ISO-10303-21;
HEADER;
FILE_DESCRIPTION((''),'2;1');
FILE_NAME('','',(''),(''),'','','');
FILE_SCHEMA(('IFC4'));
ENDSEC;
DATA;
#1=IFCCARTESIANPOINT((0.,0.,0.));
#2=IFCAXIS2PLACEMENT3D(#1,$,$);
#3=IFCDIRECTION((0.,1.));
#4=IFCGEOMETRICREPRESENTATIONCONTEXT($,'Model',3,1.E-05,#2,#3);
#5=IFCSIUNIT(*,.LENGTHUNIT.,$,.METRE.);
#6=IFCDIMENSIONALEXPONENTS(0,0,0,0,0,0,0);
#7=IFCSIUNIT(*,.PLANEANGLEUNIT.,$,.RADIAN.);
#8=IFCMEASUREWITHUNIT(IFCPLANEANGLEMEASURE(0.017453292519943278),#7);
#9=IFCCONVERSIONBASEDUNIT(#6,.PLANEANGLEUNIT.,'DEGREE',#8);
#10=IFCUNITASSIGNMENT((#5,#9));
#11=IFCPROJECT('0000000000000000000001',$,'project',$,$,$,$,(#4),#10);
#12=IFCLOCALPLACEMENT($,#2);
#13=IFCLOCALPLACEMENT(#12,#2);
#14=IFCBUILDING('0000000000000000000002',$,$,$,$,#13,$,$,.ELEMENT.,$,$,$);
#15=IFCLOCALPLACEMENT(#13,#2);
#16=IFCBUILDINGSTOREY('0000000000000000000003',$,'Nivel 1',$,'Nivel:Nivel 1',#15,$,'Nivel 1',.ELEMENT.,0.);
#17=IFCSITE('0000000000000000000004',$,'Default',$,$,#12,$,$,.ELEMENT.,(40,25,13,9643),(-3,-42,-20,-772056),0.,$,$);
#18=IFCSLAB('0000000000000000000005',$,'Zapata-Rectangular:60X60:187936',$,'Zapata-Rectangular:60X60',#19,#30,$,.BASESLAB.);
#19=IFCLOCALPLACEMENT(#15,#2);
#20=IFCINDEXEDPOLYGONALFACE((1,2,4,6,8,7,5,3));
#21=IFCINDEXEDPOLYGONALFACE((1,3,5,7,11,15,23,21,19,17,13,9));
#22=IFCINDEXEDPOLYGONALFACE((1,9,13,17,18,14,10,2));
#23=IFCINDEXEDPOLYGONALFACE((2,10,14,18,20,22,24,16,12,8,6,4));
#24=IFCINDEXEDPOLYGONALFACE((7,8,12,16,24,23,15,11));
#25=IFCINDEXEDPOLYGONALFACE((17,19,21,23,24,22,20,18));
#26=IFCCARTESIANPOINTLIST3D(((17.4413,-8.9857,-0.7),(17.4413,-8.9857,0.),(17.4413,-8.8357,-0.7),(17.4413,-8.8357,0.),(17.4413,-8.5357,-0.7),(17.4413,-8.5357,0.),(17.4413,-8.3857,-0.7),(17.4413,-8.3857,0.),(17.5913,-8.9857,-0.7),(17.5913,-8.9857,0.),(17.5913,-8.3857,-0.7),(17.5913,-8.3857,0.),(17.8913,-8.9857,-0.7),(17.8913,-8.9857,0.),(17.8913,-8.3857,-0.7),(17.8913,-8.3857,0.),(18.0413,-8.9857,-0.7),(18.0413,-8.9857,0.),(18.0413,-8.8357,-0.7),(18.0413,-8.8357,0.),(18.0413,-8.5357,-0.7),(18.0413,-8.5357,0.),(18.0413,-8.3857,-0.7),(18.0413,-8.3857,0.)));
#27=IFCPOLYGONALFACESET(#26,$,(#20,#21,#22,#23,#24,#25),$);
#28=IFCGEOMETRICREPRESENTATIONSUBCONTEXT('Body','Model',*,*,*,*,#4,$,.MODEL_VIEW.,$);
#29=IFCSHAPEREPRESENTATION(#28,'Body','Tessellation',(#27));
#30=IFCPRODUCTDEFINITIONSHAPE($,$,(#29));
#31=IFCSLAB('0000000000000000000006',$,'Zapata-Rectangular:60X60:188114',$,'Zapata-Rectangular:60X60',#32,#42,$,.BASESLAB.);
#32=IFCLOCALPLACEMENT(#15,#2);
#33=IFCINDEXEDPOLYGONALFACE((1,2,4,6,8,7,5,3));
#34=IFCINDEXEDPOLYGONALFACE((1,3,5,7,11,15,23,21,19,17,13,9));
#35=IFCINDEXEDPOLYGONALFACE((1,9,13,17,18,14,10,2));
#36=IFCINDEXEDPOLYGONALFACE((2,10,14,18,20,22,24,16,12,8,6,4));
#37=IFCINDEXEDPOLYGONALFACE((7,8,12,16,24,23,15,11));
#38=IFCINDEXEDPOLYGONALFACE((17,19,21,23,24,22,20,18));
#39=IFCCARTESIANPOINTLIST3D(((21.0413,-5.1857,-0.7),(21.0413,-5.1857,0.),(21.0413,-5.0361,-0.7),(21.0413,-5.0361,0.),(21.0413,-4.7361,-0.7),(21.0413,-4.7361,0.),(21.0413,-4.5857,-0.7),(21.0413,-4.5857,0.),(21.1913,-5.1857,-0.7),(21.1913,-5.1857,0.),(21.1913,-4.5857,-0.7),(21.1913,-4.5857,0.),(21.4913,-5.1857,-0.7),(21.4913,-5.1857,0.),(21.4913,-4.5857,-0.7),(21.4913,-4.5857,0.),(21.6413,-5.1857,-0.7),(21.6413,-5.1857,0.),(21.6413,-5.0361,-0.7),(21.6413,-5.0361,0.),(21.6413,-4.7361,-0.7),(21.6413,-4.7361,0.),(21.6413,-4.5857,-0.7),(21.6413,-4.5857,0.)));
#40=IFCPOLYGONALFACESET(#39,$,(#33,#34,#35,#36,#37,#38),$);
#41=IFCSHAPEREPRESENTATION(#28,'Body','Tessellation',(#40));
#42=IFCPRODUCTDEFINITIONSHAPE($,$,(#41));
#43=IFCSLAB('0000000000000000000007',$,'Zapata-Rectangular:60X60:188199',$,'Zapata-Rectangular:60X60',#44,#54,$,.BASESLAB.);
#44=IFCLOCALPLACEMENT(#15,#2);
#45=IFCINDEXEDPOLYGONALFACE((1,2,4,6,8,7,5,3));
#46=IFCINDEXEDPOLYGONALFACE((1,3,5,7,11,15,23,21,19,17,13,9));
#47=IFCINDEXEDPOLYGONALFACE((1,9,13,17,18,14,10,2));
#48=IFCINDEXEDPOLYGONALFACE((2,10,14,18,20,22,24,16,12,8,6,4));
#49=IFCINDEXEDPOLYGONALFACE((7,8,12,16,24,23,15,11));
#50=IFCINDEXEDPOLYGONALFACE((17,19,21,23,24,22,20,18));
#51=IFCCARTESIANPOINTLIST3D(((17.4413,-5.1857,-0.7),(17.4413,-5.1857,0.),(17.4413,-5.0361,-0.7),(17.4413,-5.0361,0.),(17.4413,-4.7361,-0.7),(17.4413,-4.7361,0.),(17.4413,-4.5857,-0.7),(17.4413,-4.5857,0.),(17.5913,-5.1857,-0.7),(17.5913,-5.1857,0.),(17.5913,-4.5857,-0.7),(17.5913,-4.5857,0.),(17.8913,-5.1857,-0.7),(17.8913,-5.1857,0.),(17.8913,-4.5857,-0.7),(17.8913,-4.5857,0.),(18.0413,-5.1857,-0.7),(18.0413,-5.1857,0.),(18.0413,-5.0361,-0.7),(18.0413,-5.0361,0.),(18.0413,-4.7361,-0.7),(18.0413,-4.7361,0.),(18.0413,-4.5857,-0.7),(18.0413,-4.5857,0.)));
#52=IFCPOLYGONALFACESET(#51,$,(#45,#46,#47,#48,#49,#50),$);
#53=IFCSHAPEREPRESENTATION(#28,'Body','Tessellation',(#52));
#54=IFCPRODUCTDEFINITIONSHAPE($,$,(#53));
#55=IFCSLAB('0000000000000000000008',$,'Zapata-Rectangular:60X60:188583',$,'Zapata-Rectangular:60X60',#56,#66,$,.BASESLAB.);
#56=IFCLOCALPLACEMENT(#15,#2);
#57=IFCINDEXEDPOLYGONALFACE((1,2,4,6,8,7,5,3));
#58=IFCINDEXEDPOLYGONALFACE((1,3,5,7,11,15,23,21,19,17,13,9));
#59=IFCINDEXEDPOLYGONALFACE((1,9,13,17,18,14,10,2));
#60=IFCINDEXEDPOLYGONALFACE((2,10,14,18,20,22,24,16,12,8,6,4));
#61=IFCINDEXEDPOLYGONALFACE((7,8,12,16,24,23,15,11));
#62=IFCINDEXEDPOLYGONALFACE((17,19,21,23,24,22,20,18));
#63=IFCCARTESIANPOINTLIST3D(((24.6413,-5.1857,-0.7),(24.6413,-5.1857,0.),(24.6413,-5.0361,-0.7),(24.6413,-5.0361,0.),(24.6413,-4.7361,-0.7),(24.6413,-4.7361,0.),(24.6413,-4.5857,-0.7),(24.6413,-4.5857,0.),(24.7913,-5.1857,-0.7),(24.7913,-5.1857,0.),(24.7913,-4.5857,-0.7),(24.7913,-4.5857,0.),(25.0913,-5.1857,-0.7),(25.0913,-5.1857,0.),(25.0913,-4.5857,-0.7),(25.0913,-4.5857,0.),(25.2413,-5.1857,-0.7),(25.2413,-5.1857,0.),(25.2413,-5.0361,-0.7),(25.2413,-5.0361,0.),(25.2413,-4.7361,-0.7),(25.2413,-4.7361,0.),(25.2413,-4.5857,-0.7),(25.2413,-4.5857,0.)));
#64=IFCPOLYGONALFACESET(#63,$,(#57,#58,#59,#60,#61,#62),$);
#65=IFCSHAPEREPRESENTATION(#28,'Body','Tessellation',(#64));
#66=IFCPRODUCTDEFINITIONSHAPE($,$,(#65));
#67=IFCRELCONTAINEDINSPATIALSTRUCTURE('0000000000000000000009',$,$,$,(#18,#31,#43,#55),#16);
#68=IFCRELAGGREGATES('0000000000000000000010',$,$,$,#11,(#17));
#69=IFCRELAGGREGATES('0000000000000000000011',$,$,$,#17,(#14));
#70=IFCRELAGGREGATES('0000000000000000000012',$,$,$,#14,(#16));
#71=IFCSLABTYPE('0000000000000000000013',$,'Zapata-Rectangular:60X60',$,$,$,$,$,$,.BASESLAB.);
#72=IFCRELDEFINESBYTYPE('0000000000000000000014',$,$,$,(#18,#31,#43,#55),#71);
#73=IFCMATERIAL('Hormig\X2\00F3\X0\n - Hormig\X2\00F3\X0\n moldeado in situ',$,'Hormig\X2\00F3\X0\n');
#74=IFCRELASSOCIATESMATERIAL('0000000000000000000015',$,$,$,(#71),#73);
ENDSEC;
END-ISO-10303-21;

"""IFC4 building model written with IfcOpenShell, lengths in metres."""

from ifc_helpers import new_model, entity, si_unit, converted_unit, direction, frame, origin, place, context, subcontext, project, spatial, indexed_curve, outline, extrude, material, type_object, element, save


model = new_model("IFC4")

# Units and contexts
model_context = context("Model", 3, precision=1e-05, world=origin(), true_north=direction((0.0, 1.0)))
body_context = subcontext(model_context, "Body", "Model", "MODEL_VIEW")
ifc_project = project(units=[si_unit("LENGTHUNIT", "METRE"), converted_unit("PLANEANGLEUNIT", "DEGREE", entity("IfcPlaneAngleMeasure", 0.017453292519943278), si_unit("PLANEANGLEUNIT", "RADIAN"), dimensions=[0, 0, 0, 0, 0, 0, 0])], contexts=[model_context])

# Site, building, storey
site_placement = place(None, origin())
site = spatial("IfcSite", under=ifc_project, at=site_placement, Name="Default", CompositionType="ELEMENT", RefLatitude=(40, 25, 13, 9643), RefLongitude=(-3, -42, -20, -772056), RefElevation=0.0)
building_placement = place(site_placement, origin())
building = spatial("IfcBuilding", under=site, at=building_placement, CompositionType="ELEMENT")
storey_placement = place(building_placement, origin())
storey = spatial("IfcBuildingStorey", under=building, at=storey_placement, Name="Nivel 1", ObjectType="Nivel:Nivel 1", LongName="Nivel 1", CompositionType="ELEMENT", Elevation=0.0)

# Slabs
ifc_material_1 = material(Name="Hormigón - Hormigón moldeado in situ", Category="Hormigón")
slab_type = type_object("IfcSlabType", Name="Zapata-Rectangular:60X60", PredefinedType="BASESLAB", material=ifc_material_1)
slab_1_placement = place(storey_placement, origin())
element("IfcSlab", 1, at=slab_1_placement, inside=storey, type_object=slab_type, Name="Zapata-Rectangular:60X60:187936", ObjectType="Zapata-Rectangular:60X60", PredefinedType="BASESLAB", context=body_context, shape_type="SweptSolid", body=[
    extrude(outline(indexed_curve([(-0.3, -0.3), (-0.15, -0.3), (0.15, -0.3), (0.3, -0.3), (0.3, -0.15), (0.3, 0.15), (0.3, 0.3), (0.15, 0.3), (-0.15, 0.3), (-0.3, 0.3), (-0.3, 0.15), (-0.3, -0.15), (-0.3, -0.3)], self_intersect=False)), frame((17.7413, -8.6857, -0.7), z_axis=(0.0, 0.0, 1.0), x_axis=(-1.0, 0.0, 0.0)), (0.0, 0.0, 1.0), 0.7),
])
slab_2_placement = place(storey_placement, origin())
element("IfcSlab", 2, at=slab_2_placement, inside=storey, type_object=slab_type, Name="Zapata-Rectangular:60X60:188114", ObjectType="Zapata-Rectangular:60X60", PredefinedType="BASESLAB", context=body_context, shape_type="SweptSolid", body=[
    extrude(outline(indexed_curve([(-0.3, -0.3001), (-0.15, -0.3001), (0.15, -0.3001), (0.3, -0.3001), (0.3, -0.1498), (0.3, 0.1502), (0.3, 0.2999), (0.15, 0.2999), (-0.15, 0.2999), (-0.3, 0.2999), (-0.3, 0.1502), (-0.3, -0.1498), (-0.3, -0.3001)], self_intersect=False)), frame((21.3413, -4.8858, -0.7), z_axis=(0.0, 0.0, 1.0), x_axis=(-1.0, 0.0, 0.0)), (0.0, 0.0, 1.0), 0.7),
])
slab_3_placement = place(storey_placement, origin())
element("IfcSlab", 3, at=slab_3_placement, inside=storey, type_object=slab_type, Name="Zapata-Rectangular:60X60:188199", ObjectType="Zapata-Rectangular:60X60", PredefinedType="BASESLAB", context=body_context, shape_type="SweptSolid", body=[
    extrude(outline(indexed_curve([(-0.3, -0.3001), (-0.15, -0.3001), (0.15, -0.3001), (0.3, -0.3001), (0.3, -0.1498), (0.3, 0.1502), (0.3, 0.2999), (0.15, 0.2999), (-0.15, 0.2999), (-0.3, 0.2999), (-0.3, 0.1502), (-0.3, -0.1498), (-0.3, -0.3001)], self_intersect=False)), frame((17.7413, -4.8858, -0.7), z_axis=(0.0, 0.0, 1.0), x_axis=(-1.0, 0.0, 0.0)), (0.0, 0.0, 1.0), 0.7),
])
slab_4_placement = place(storey_placement, origin())
element("IfcSlab", 4, at=slab_4_placement, inside=storey, type_object=slab_type, Name="Zapata-Rectangular:60X60:188583", ObjectType="Zapata-Rectangular:60X60", PredefinedType="BASESLAB", context=body_context, shape_type="SweptSolid", body=[
    extrude(outline(indexed_curve([(-0.3, -0.3001), (-0.15, -0.3001), (0.15, -0.3001), (0.3, -0.3001), (0.3, -0.1498), (0.3, 0.1502), (0.3, 0.2999), (0.15, 0.2999), (-0.15, 0.2999), (-0.3, 0.2999), (-0.3, 0.1502), (-0.3, -0.1498), (-0.3, -0.3001)], self_intersect=False)), frame((24.9413, -4.8858, -0.7), z_axis=(0.0, 0.0, 1.0), x_axis=(-1.0, 0.0, 0.0)), (0.0, 0.0, 1.0), 0.7),
])

save(model, "model.ifc")
